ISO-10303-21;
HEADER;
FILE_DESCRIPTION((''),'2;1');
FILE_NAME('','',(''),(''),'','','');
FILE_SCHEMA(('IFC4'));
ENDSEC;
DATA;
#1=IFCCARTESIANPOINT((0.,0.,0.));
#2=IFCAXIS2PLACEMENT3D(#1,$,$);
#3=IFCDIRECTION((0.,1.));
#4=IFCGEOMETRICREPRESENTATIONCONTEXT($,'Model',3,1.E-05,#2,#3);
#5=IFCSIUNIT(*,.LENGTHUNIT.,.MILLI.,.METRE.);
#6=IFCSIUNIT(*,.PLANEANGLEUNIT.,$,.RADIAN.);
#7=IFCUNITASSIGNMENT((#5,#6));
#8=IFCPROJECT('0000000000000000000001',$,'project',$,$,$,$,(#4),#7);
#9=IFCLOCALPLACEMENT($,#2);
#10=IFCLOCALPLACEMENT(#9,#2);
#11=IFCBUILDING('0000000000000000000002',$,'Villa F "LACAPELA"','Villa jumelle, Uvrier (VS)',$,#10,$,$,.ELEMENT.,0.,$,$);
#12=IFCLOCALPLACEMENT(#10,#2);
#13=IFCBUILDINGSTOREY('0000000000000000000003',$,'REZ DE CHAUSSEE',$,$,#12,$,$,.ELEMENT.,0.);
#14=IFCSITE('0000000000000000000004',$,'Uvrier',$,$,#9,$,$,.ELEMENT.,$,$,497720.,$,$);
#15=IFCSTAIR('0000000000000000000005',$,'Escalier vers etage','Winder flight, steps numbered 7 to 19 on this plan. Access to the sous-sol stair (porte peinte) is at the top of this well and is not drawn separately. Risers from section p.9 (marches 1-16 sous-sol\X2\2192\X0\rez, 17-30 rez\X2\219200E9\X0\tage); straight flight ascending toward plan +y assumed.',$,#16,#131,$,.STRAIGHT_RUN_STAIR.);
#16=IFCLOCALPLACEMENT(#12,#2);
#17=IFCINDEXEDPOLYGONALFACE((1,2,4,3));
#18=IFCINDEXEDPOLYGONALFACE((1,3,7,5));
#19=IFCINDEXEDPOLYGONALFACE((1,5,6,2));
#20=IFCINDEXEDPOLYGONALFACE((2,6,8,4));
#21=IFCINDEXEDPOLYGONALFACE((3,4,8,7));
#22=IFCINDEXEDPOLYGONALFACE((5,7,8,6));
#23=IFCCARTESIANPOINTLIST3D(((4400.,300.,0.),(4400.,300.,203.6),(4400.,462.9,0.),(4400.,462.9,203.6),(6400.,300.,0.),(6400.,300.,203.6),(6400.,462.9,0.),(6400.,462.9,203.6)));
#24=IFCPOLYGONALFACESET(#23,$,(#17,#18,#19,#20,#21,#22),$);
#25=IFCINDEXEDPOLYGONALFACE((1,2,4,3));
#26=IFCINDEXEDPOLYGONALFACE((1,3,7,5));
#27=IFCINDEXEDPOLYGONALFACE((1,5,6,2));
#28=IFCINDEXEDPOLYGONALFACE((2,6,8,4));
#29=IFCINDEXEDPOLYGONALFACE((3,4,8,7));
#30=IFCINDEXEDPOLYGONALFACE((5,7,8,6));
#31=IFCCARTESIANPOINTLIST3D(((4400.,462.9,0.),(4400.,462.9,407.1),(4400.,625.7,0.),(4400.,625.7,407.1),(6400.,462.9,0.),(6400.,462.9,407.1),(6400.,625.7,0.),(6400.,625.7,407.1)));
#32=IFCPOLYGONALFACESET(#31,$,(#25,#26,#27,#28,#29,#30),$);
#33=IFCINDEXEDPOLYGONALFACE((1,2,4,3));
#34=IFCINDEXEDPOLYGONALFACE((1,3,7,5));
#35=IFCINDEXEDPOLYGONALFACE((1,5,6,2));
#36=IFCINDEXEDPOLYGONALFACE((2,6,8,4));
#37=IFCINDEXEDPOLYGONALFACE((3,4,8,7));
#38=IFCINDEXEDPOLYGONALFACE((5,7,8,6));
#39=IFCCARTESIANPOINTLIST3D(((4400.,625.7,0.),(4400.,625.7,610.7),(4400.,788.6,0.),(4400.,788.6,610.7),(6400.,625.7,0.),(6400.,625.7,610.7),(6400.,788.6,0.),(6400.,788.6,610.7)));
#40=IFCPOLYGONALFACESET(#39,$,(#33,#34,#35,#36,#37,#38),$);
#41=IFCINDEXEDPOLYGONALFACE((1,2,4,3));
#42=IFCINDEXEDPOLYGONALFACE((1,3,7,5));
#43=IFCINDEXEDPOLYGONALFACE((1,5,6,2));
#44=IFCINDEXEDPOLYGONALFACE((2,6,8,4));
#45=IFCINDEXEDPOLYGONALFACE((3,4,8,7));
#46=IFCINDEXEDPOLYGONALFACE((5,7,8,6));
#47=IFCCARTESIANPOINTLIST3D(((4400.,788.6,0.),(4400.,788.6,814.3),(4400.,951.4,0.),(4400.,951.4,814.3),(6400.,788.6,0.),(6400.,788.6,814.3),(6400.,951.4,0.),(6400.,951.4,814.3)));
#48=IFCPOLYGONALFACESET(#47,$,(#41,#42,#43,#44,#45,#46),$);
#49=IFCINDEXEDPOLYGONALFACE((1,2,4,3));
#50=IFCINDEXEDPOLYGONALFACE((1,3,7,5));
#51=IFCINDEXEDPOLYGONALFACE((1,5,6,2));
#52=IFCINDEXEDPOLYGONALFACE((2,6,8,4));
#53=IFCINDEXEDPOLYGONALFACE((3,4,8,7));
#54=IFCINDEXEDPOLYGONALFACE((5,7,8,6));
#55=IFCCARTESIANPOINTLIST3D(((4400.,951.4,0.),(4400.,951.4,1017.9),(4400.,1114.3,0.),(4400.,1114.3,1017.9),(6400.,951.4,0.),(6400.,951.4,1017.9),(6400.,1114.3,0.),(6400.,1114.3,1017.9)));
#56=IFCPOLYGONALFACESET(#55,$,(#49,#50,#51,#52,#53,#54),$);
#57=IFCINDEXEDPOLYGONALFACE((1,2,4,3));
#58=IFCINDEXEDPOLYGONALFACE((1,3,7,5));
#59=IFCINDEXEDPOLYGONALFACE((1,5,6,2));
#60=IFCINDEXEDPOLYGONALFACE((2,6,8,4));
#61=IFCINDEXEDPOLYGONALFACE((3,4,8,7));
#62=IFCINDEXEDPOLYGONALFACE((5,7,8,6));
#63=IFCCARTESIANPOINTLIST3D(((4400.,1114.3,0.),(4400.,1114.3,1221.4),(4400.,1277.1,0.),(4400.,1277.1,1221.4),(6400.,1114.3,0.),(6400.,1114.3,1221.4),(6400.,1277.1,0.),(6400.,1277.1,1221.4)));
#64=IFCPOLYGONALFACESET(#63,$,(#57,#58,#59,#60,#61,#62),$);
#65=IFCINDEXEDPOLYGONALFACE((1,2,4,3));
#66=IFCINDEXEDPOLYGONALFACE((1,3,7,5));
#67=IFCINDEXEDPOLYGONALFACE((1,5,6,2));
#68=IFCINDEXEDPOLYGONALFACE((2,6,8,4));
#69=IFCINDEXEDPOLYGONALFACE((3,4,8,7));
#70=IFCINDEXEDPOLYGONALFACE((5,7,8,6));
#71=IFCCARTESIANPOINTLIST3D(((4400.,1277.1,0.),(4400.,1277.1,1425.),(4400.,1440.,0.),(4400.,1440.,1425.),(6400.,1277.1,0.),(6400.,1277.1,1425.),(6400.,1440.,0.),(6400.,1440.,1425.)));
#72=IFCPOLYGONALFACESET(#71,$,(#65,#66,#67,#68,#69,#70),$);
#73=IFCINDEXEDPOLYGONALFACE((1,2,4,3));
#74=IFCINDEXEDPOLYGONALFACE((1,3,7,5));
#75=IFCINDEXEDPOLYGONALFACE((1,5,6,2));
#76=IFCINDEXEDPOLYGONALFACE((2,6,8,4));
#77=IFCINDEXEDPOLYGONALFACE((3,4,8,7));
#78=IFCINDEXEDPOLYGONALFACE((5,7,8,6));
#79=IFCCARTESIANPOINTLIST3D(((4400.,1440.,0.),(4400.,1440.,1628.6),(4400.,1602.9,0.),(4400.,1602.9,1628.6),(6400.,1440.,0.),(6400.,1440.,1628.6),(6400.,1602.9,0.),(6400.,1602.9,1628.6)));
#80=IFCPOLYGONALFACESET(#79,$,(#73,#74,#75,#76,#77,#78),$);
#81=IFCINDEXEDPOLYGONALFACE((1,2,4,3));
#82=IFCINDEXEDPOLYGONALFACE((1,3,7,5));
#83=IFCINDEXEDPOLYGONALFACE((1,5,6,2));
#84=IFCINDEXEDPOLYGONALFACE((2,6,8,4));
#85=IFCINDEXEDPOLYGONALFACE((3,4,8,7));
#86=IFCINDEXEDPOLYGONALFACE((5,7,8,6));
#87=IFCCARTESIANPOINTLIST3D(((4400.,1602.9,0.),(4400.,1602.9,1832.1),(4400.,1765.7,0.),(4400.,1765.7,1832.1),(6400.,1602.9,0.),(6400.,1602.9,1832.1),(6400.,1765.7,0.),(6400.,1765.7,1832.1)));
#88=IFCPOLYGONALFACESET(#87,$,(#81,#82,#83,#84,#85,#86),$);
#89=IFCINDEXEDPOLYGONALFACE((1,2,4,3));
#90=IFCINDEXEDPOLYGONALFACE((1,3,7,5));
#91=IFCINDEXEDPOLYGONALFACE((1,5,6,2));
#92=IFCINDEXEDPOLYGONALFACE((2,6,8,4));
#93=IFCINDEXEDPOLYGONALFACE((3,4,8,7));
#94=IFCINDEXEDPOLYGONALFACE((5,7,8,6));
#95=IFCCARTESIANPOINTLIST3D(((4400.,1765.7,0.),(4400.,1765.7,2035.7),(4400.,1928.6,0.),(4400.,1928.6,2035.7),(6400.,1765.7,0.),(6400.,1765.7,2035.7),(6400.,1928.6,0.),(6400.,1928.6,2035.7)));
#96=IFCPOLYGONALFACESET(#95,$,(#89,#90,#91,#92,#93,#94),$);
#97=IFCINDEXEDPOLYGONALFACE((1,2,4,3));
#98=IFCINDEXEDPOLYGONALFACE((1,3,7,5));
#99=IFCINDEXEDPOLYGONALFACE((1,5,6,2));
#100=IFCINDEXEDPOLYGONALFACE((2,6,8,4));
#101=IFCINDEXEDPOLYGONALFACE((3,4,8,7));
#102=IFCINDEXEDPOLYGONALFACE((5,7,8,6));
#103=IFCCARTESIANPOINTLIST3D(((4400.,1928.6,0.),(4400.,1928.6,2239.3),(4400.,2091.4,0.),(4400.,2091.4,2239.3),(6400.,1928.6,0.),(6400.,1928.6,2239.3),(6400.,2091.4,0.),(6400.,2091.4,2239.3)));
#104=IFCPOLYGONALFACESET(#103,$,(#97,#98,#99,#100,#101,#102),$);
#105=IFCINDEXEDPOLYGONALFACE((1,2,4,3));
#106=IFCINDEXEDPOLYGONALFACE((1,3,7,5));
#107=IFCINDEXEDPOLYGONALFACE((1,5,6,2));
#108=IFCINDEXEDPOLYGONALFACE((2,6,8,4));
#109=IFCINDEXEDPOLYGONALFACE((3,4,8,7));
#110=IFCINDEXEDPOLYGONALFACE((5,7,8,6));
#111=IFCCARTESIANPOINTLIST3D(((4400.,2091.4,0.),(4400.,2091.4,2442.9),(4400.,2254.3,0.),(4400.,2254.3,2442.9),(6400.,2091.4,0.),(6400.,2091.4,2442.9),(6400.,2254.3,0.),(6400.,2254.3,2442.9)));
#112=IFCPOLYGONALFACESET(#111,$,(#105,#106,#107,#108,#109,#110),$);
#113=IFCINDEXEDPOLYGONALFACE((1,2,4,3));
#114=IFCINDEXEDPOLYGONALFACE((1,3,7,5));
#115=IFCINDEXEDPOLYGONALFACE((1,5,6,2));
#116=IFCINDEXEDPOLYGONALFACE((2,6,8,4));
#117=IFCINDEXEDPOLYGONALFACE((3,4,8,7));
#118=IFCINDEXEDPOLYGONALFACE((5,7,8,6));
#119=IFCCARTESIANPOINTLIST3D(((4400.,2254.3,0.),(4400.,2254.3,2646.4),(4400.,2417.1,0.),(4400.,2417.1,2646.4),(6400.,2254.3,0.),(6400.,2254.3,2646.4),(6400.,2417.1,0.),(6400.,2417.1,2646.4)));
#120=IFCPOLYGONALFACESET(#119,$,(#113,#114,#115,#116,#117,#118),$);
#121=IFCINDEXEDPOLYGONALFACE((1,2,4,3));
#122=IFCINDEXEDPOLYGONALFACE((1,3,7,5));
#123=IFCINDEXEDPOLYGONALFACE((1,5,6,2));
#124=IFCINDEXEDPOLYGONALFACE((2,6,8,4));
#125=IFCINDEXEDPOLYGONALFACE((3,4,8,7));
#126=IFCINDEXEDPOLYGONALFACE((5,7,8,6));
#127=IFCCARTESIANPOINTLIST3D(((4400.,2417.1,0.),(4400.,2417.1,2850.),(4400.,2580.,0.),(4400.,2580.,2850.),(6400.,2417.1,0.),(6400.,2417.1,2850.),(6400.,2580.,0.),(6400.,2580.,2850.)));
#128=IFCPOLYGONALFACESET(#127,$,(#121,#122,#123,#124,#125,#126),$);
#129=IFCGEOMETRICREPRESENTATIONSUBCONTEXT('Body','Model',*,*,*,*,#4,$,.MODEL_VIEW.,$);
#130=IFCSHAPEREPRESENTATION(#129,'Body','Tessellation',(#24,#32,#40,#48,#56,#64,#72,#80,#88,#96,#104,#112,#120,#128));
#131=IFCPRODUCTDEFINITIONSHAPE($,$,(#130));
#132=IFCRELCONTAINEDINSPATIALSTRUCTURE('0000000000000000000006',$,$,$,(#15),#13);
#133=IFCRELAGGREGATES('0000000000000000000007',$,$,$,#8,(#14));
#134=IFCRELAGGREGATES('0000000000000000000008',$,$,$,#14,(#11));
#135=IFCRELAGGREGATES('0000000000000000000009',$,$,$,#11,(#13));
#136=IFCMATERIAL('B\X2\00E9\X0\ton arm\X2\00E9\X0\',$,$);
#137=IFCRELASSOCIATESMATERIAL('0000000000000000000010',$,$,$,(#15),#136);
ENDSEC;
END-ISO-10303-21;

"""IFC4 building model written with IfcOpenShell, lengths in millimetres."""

from ifc_helpers import new_model, si_unit, direction, frame_2d, origin, place, context, subcontext, project, spatial, rectangle, extrude, material, element, save


model = new_model("IFC4")

# Units and contexts
model_context = context("Model", 3, precision=1e-05, world=origin(), true_north=direction((0.0, 1.0)))
body_context = subcontext(model_context, "Body", "Model", "MODEL_VIEW")
ifc_project = project(units=[si_unit("LENGTHUNIT", "METRE", prefix="MILLI"), si_unit("PLANEANGLEUNIT", "RADIAN")], contexts=[model_context])

# Site, building, storey
site_placement = place(None, origin())
site = spatial("IfcSite", under=ifc_project, at=site_placement, Name="Uvrier", CompositionType="ELEMENT", RefElevation=497720.0)
building_placement = place(site_placement, origin())
building = spatial("IfcBuilding", under=site, at=building_placement, Name="Villa F \"LACAPELA\"", Description="Villa jumelle, Uvrier (VS)", CompositionType="ELEMENT", ElevationOfRefHeight=0.0)
storey_placement = place(building_placement, origin())
storey = spatial("IfcBuildingStorey", under=building, at=storey_placement, Name="REZ DE CHAUSSEE", CompositionType="ELEMENT", Elevation=0.0)

# Shared definitions
ifc_material_1 = material(Name="Béton armé")

# Stair
stair_placement = place(storey_placement, origin())
element("IfcStair", 1, at=stair_placement, inside=storey, material=ifc_material_1, Name="Escalier vers etage", Description="Winder flight, steps numbered 7 to 19 on this plan. Access to the sous-sol stair (porte peinte) is at the top of this well and is not drawn separately. Risers from section p.9 (marches 1-16 sous-sol→rez, 17-30 rez→étage); straight flight ascending toward plan +y assumed.", PredefinedType="STRAIGHT_RUN_STAIR", context=body_context, shape_type="SweptSolid", body=[
    extrude(rectangle(XDim=162.9, YDim=2000.0, at=frame_2d((5400.0, 381.4), x_axis=(0.0, 1.0))), origin(), (0.0, 0.0, 1.0), 203.6),
    extrude(rectangle(XDim=162.9, YDim=2000.0, at=frame_2d((5400.0, 544.3), x_axis=(0.0, 1.0))), origin(), (0.0, 0.0, 1.0), 407.1),
    extrude(rectangle(XDim=162.9, YDim=2000.0, at=frame_2d((5400.0, 707.1), x_axis=(0.0, 1.0))), origin(), (0.0, 0.0, 1.0), 610.7),
    extrude(rectangle(XDim=162.9, YDim=2000.0, at=frame_2d((5400.0, 870.0), x_axis=(0.0, 1.0))), origin(), (0.0, 0.0, 1.0), 814.3),
    extrude(rectangle(XDim=162.9, YDim=2000.0, at=frame_2d((5400.0, 1032.9), x_axis=(0.0, 1.0))), origin(), (0.0, 0.0, 1.0), 1017.9),
    extrude(rectangle(XDim=162.9, YDim=2000.0, at=frame_2d((5400.0, 1195.7), x_axis=(0.0, 1.0))), origin(), (0.0, 0.0, 1.0), 1221.4),
    extrude(rectangle(XDim=162.9, YDim=2000.0, at=frame_2d((5400.0, 1358.6), x_axis=(0.0, 1.0))), origin(), (0.0, 0.0, 1.0), 1425.0),
    extrude(rectangle(XDim=162.9, YDim=2000.0, at=frame_2d((5400.0, 1521.4), x_axis=(0.0, 1.0))), origin(), (0.0, 0.0, 1.0), 1628.6),
    extrude(rectangle(XDim=162.9, YDim=2000.0, at=frame_2d((5400.0, 1684.3), x_axis=(0.0, 1.0))), origin(), (0.0, 0.0, 1.0), 1832.1),
    extrude(rectangle(XDim=162.9, YDim=2000.0, at=frame_2d((5400.0, 1847.1), x_axis=(0.0, 1.0))), origin(), (0.0, 0.0, 1.0), 2035.7),
    extrude(rectangle(XDim=162.9, YDim=2000.0, at=frame_2d((5400.0, 2010.0), x_axis=(0.0, 1.0))), origin(), (0.0, 0.0, 1.0), 2239.3),
    extrude(rectangle(XDim=162.9, YDim=2000.0, at=frame_2d((5400.0, 2172.9), x_axis=(0.0, 1.0))), origin(), (0.0, 0.0, 1.0), 2442.9),
    extrude(rectangle(XDim=162.9, YDim=2000.0, at=frame_2d((5400.0, 2335.7), x_axis=(0.0, 1.0))), origin(), (0.0, 0.0, 1.0), 2646.4),
    extrude(rectangle(XDim=162.9, YDim=2000.0, at=frame_2d((5400.0, 2498.6), x_axis=(0.0, 1.0))), origin(), (0.0, 0.0, 1.0), 2850.0),
])

save(model, "model.ifc")
